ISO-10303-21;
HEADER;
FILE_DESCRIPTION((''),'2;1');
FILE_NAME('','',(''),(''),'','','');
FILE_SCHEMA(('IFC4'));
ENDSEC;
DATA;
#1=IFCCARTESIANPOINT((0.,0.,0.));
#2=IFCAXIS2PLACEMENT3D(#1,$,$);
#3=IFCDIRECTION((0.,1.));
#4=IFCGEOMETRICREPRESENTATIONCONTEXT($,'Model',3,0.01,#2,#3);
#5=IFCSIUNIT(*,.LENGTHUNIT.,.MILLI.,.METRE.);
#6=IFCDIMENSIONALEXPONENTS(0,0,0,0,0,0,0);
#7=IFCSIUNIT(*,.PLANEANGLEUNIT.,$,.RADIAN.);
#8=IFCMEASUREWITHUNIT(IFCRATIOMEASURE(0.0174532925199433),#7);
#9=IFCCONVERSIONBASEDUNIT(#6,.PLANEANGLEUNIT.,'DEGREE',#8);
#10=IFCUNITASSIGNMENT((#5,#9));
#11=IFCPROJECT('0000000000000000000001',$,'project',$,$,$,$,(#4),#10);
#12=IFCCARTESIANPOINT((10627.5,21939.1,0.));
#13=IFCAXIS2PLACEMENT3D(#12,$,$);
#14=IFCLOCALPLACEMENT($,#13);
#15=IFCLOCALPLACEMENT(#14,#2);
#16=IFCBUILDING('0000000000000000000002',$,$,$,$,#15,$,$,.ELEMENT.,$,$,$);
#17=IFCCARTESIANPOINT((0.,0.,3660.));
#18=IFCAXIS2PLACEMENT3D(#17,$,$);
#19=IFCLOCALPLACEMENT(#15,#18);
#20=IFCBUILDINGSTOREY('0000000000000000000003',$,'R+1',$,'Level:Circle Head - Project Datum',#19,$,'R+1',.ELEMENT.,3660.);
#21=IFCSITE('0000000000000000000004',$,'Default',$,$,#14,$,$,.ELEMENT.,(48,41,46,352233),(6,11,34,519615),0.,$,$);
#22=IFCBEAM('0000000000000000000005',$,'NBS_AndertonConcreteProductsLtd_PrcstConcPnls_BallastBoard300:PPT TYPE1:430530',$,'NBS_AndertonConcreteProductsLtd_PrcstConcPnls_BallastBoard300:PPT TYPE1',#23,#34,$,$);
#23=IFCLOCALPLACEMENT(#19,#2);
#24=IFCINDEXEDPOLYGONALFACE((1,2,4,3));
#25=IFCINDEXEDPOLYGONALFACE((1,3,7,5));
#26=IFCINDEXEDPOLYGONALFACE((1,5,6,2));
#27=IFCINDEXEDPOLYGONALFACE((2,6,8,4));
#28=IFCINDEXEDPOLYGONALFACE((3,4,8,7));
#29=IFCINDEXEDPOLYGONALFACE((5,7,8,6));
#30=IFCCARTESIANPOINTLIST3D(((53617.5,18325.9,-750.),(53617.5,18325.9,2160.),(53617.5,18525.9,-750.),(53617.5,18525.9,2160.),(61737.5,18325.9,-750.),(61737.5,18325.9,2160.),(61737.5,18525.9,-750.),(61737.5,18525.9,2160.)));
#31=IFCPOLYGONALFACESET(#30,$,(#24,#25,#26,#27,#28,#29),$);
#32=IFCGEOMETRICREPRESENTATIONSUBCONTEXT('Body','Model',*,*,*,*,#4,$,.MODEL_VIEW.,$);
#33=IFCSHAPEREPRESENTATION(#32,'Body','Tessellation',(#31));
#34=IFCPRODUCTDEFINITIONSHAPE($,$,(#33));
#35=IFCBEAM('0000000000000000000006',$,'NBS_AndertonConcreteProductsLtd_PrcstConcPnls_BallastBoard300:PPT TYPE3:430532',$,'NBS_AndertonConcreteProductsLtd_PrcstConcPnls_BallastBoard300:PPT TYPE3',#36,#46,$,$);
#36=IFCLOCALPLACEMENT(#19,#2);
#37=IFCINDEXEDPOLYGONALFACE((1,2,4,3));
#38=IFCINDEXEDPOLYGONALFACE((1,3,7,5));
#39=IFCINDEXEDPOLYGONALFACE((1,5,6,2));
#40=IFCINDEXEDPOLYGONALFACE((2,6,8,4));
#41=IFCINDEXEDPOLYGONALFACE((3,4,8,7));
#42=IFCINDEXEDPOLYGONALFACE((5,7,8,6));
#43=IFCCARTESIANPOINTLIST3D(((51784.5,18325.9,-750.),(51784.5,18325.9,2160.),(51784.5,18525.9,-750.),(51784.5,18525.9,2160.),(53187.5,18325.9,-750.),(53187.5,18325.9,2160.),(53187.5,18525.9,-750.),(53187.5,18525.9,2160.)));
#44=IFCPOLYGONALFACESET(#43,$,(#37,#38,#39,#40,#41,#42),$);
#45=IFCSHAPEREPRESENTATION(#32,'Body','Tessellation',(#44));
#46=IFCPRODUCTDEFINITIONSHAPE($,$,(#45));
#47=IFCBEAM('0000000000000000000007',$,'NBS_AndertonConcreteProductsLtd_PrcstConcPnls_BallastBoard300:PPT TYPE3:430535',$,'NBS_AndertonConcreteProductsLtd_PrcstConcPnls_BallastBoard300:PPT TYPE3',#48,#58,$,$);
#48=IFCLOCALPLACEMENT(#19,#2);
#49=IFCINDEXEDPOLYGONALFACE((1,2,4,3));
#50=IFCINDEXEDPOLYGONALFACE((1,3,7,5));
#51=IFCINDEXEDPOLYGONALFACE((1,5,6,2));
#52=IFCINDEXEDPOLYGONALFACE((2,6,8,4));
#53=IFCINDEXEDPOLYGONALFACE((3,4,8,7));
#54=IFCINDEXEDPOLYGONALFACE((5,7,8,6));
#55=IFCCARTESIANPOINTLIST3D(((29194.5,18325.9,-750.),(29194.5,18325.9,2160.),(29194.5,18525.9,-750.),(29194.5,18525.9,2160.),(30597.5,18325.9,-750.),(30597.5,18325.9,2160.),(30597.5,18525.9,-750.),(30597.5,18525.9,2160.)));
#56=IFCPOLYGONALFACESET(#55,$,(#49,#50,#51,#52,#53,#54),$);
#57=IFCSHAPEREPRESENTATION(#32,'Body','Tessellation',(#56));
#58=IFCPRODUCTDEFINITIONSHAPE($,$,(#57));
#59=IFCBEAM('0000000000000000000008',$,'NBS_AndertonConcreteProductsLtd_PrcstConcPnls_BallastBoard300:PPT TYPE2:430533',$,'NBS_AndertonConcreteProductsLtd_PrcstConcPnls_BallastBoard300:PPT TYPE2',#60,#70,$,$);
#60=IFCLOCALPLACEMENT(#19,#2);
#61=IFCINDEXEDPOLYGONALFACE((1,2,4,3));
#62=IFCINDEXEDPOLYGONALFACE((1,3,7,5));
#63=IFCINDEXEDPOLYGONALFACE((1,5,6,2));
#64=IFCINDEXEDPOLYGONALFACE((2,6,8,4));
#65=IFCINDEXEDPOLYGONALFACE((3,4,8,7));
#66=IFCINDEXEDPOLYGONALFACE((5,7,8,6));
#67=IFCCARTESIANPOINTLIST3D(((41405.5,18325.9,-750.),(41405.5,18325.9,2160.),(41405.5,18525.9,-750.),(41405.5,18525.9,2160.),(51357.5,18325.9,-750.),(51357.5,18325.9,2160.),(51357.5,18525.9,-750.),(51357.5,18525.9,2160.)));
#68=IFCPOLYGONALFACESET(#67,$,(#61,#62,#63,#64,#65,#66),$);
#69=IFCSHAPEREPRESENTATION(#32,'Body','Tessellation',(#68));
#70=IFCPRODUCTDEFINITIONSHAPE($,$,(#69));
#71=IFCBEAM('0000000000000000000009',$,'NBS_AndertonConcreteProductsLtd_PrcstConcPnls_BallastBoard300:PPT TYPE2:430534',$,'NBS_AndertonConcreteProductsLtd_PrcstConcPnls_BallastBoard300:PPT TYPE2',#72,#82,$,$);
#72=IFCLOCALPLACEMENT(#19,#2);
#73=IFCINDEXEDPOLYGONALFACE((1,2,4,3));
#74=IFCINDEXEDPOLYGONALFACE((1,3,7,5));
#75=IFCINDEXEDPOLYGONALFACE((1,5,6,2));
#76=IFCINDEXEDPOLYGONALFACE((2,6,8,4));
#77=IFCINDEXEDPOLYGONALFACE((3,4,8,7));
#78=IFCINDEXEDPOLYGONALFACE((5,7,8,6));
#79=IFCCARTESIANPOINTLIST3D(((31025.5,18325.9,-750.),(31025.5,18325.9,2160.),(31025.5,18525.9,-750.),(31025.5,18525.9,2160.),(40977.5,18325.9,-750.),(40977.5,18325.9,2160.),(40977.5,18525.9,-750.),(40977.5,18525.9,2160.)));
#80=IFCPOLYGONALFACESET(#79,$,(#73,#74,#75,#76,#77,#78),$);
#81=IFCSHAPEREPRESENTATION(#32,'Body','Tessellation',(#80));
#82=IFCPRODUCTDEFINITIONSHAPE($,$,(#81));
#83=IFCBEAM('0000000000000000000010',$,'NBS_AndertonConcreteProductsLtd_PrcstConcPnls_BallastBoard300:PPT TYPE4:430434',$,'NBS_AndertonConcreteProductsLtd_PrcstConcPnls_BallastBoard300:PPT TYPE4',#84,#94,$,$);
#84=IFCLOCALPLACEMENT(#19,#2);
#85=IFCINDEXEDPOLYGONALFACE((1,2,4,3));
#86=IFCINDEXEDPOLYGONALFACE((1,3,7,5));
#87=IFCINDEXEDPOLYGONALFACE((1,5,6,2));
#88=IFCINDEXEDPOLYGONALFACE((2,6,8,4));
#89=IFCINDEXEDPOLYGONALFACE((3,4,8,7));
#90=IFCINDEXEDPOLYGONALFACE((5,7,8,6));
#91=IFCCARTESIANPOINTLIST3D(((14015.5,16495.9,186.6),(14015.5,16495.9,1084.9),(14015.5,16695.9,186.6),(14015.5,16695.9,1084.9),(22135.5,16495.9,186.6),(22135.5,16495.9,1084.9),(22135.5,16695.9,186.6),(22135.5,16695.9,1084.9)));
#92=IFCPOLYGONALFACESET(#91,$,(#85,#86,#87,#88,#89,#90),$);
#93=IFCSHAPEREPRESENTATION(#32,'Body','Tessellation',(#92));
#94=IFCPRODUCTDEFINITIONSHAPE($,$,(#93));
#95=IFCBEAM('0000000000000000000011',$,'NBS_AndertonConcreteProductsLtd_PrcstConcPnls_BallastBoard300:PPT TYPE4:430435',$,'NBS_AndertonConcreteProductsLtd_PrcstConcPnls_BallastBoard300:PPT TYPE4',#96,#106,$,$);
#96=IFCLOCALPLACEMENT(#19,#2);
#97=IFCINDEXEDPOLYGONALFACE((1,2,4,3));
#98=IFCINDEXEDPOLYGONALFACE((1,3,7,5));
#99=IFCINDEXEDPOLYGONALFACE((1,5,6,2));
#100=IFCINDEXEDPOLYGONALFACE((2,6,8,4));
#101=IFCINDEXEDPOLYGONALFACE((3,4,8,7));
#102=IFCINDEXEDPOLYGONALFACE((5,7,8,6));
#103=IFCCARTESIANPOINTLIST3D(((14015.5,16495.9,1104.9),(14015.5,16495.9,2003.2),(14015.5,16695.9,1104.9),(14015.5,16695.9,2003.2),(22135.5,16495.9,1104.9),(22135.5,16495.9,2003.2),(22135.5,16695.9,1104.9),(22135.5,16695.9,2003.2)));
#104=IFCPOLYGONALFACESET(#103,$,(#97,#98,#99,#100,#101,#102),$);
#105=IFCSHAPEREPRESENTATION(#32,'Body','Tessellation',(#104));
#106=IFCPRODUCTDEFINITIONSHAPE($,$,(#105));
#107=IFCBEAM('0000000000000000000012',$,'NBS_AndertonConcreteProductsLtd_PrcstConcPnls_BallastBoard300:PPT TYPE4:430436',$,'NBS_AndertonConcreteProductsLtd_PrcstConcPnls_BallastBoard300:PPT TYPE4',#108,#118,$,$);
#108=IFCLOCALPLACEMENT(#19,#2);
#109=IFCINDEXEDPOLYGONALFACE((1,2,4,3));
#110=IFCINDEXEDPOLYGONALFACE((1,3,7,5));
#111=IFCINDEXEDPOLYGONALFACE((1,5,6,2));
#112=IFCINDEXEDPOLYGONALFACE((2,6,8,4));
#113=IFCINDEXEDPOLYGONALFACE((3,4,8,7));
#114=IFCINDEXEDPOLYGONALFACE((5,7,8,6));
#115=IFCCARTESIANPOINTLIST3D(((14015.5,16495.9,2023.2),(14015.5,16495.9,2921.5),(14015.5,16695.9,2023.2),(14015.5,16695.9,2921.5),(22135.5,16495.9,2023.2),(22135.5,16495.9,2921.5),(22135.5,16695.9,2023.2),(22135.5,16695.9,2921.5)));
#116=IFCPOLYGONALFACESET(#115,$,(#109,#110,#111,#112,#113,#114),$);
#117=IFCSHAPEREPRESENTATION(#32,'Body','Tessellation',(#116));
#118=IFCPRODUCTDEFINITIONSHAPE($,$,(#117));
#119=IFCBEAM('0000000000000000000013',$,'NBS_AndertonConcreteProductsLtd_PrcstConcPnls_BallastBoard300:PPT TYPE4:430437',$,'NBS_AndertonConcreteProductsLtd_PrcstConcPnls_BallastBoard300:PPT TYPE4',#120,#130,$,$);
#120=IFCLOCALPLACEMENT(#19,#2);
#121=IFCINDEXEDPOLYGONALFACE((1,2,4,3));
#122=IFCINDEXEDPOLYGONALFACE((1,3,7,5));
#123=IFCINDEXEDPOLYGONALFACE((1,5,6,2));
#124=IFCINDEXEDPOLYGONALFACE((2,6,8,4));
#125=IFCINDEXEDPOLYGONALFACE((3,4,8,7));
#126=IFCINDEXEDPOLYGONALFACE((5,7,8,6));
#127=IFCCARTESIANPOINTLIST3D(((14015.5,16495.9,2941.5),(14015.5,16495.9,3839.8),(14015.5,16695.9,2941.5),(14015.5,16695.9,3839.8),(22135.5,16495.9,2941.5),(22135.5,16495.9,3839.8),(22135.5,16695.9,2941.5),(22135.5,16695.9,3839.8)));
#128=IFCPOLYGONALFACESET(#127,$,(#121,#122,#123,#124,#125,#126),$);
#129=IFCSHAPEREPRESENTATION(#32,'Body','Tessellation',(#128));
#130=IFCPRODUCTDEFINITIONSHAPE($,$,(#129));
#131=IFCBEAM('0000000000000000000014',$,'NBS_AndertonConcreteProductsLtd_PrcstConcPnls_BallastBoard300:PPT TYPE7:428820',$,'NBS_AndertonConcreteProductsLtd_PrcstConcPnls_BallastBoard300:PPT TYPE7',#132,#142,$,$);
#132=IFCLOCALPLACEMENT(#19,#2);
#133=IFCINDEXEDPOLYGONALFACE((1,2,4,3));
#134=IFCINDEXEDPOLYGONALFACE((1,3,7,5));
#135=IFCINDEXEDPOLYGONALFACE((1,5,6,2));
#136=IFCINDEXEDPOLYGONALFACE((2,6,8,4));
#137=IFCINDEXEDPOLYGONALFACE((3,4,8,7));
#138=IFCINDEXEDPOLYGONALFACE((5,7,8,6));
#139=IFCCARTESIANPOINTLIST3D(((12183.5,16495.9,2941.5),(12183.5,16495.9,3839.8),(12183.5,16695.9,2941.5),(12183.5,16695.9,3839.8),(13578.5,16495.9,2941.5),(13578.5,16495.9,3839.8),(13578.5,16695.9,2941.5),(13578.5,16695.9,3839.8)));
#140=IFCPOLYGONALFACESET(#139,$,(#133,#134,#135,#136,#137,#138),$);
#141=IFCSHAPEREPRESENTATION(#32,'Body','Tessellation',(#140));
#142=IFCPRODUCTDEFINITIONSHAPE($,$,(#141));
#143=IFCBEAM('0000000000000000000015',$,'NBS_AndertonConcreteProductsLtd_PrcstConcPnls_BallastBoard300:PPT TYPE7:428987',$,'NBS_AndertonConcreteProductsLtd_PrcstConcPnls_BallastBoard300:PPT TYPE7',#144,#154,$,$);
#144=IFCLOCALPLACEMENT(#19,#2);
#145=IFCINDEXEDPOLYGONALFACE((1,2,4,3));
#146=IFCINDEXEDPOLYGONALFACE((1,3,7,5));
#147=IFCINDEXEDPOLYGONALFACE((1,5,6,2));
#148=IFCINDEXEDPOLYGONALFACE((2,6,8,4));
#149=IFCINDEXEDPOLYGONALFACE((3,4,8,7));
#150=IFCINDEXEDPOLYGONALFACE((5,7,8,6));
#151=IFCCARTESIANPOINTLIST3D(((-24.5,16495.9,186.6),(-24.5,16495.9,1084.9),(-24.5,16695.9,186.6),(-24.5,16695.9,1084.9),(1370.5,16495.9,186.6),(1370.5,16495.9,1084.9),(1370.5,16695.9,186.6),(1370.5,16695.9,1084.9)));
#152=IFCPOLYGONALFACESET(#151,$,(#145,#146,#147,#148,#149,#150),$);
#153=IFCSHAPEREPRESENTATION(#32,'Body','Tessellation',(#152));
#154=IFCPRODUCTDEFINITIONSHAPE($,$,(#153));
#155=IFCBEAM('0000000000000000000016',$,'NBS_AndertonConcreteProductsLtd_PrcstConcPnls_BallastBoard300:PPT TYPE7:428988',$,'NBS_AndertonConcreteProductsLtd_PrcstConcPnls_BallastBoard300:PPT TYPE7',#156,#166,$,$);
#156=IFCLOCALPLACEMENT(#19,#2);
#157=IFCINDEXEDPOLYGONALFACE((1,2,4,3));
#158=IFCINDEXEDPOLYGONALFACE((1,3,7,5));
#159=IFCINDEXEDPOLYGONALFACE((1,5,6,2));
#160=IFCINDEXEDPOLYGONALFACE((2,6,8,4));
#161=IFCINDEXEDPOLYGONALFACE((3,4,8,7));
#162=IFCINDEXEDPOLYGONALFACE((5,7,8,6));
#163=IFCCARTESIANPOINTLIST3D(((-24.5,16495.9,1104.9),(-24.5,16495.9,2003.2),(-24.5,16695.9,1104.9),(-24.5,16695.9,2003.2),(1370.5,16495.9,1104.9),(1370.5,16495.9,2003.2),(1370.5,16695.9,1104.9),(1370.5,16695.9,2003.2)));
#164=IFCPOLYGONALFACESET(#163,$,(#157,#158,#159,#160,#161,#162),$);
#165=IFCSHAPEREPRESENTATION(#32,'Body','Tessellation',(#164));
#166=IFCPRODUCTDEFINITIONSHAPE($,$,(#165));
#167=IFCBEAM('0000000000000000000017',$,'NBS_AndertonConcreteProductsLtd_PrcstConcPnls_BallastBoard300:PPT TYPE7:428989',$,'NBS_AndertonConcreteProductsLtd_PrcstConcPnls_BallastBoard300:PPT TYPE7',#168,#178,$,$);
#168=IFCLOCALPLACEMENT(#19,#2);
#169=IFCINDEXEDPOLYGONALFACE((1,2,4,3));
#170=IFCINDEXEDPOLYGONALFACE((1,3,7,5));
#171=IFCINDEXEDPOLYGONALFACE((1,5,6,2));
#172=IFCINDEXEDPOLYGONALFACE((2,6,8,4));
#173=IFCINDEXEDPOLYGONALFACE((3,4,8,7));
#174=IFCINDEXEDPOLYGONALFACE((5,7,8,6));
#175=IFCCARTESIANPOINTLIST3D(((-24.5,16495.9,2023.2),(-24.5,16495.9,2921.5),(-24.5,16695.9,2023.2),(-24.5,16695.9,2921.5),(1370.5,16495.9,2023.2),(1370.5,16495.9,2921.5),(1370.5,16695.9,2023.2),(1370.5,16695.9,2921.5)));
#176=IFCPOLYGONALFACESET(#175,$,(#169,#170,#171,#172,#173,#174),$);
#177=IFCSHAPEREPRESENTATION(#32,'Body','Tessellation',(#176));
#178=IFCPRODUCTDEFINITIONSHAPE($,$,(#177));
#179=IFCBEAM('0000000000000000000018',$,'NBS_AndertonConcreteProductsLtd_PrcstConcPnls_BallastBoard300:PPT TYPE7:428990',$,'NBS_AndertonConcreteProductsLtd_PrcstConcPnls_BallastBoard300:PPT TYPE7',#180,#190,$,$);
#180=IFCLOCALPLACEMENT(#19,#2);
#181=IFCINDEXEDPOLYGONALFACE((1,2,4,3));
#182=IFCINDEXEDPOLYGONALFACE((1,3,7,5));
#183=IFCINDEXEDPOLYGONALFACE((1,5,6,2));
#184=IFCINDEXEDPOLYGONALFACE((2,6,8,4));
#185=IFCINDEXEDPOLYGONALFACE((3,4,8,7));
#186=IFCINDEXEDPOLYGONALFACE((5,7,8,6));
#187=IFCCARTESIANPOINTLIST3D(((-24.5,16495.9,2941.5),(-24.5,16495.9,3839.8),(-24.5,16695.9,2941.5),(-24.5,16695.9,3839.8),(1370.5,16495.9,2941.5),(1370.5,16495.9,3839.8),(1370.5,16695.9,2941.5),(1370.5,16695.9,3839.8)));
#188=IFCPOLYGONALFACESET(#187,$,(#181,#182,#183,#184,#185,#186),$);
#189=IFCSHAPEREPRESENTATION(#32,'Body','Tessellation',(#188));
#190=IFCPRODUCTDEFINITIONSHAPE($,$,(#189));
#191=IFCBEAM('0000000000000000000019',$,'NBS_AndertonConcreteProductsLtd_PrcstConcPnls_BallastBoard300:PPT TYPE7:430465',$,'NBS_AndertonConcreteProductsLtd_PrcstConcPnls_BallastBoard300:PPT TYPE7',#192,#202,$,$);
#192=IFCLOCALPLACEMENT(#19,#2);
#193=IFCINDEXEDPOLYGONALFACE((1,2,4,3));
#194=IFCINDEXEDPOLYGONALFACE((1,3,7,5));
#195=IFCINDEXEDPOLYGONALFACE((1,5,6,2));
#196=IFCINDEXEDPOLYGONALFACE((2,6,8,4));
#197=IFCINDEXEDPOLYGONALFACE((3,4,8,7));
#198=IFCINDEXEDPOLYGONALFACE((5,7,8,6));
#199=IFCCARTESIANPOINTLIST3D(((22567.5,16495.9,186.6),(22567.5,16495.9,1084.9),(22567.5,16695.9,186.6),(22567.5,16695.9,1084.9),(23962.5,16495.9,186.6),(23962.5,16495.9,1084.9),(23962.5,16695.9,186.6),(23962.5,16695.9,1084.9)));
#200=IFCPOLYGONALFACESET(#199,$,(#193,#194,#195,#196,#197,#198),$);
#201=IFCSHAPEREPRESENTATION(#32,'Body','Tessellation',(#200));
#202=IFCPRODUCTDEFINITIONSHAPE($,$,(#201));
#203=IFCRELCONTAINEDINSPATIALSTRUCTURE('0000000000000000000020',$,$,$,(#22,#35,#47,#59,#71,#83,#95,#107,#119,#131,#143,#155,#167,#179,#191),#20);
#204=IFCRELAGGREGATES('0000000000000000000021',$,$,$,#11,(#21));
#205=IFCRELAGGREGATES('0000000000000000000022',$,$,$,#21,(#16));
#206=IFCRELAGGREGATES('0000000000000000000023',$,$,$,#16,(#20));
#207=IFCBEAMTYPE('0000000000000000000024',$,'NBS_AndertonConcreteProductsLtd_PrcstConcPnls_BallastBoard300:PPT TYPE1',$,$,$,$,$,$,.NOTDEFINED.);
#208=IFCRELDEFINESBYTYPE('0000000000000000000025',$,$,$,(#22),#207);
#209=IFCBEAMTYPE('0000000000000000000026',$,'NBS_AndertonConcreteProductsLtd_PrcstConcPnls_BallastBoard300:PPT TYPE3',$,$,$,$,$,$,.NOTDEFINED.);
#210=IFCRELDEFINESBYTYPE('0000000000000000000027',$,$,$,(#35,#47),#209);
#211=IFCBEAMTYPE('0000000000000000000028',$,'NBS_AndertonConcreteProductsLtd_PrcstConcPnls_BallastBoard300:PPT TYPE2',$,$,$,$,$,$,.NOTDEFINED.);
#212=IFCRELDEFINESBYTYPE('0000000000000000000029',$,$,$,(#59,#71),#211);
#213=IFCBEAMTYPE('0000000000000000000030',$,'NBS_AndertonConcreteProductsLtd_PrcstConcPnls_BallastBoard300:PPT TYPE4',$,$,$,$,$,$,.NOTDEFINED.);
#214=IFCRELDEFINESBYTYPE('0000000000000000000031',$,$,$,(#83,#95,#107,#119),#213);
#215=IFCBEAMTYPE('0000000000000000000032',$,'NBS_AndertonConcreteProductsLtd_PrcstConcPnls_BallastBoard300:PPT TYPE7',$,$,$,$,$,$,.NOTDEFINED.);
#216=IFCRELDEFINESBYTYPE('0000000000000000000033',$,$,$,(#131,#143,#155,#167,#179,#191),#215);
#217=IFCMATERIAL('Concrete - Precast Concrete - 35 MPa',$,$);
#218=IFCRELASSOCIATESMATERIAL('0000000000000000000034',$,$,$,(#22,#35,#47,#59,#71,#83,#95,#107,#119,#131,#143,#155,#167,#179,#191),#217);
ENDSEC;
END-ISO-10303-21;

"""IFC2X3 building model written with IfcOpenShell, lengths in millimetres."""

from ifc_helpers import new_model, entity, si_unit, converted_unit, direction, frame, frame_2d, origin, place, context, subcontext, project, spatial, rectangle, extrude, material, type_object, element, save


model = new_model("IFC2X3")

# Units and contexts
model_context = context("Model", 3, precision=0.01, world=origin(), true_north=direction((0.0, 1.0)))
body_context = subcontext(model_context, "Body", "Model", "MODEL_VIEW")
ifc_project = project(units=[si_unit("LENGTHUNIT", "METRE", prefix="MILLI"), converted_unit("PLANEANGLEUNIT", "DEGREE", entity("IfcRatioMeasure", 0.0174532925199433), si_unit("PLANEANGLEUNIT", "RADIAN"), dimensions=[0, 0, 0, 0, 0, 0, 0])], contexts=[model_context])

# Site, building, storey
site_placement = place(None, frame((10627.5, 21939.1, 0.0)))
site = spatial("IfcSite", under=ifc_project, at=site_placement, Name="Default", CompositionType="ELEMENT", RefLatitude=(48, 41, 46, 352233), RefLongitude=(6, 11, 34, 519615), RefElevation=0.0)
building_placement = place(site_placement, origin())
building = spatial("IfcBuilding", under=site, at=building_placement, CompositionType="ELEMENT")
storey_placement = place(building_placement, frame((0.0, 0.0, 3660.0)))
storey = spatial("IfcBuildingStorey", under=building, at=storey_placement, Name="R+1", ObjectType="Level:Circle Head - Project Datum", LongName="R+1", CompositionType="ELEMENT", Elevation=3660.0)

# Beams
ifc_material_1 = material(Name="Concrete - Precast Concrete - 35 MPa")
beam_type_1 = type_object("IfcBeamType", Name="NBS_AndertonConcreteProductsLtd_PrcstConcPnls_BallastBoard300:PPT TYPE1", PredefinedType="NOTDEFINED")
beam_1_placement = place(storey_placement, origin())
element("IfcBeam", 1, at=beam_1_placement, inside=storey, type_object=beam_type_1, material=ifc_material_1, Name="NBS_AndertonConcreteProductsLtd_PrcstConcPnls_BallastBoard300:PPT TYPE1:430530", ObjectType="NBS_AndertonConcreteProductsLtd_PrcstConcPnls_BallastBoard300:PPT TYPE1", context=body_context, shape_type="SweptSolid", body=[
    extrude(rectangle(XDim=2910.0, YDim=200.0, at=frame_2d((0.0, 0.0), x_axis=(1.0, 0.0))), frame((53617.5, 18425.9, 705.0), z_axis=(1.0, 0.0, 0.0), x_axis=(0.0, 0.0, -1.0)), (0.0, 0.0, 1.0), 8120.0),
])
beam_type_2 = type_object("IfcBeamType", Name="NBS_AndertonConcreteProductsLtd_PrcstConcPnls_BallastBoard300:PPT TYPE3", PredefinedType="NOTDEFINED")
beam_2_placement = place(storey_placement, origin())
element("IfcBeam", 2, at=beam_2_placement, inside=storey, type_object=beam_type_2, material=ifc_material_1, Name="NBS_AndertonConcreteProductsLtd_PrcstConcPnls_BallastBoard300:PPT TYPE3:430532", ObjectType="NBS_AndertonConcreteProductsLtd_PrcstConcPnls_BallastBoard300:PPT TYPE3", context=body_context, shape_type="SweptSolid", body=[
    extrude(rectangle(XDim=2910.0, YDim=200.0, at=frame_2d((0.0, 0.0), x_axis=(1.0, 0.0))), frame((51784.5, 18425.9, 705.0), z_axis=(1.0, 0.0, 0.0), x_axis=(0.0, 0.0, -1.0)), (0.0, 0.0, 1.0), 1403.0),
])
beam_3_placement = place(storey_placement, origin())
element("IfcBeam", 3, at=beam_3_placement, inside=storey, type_object=beam_type_2, material=ifc_material_1, Name="NBS_AndertonConcreteProductsLtd_PrcstConcPnls_BallastBoard300:PPT TYPE3:430535", ObjectType="NBS_AndertonConcreteProductsLtd_PrcstConcPnls_BallastBoard300:PPT TYPE3", context=body_context, shape_type="SweptSolid", body=[
    extrude(rectangle(XDim=2910.0, YDim=200.0, at=frame_2d((0.0, 0.0), x_axis=(1.0, 0.0))), frame((29194.5, 18425.9, 705.0), z_axis=(1.0, 0.0, 0.0), x_axis=(0.0, 0.0, -1.0)), (0.0, 0.0, 1.0), 1403.0),
])
beam_type_3 = type_object("IfcBeamType", Name="NBS_AndertonConcreteProductsLtd_PrcstConcPnls_BallastBoard300:PPT TYPE2", PredefinedType="NOTDEFINED")
beam_4_placement = place(storey_placement, origin())
element("IfcBeam", 4, at=beam_4_placement, inside=storey, type_object=beam_type_3, material=ifc_material_1, Name="NBS_AndertonConcreteProductsLtd_PrcstConcPnls_BallastBoard300:PPT TYPE2:430533", ObjectType="NBS_AndertonConcreteProductsLtd_PrcstConcPnls_BallastBoard300:PPT TYPE2", context=body_context, shape_type="SweptSolid", body=[
    extrude(rectangle(XDim=2910.0, YDim=200.0, at=frame_2d((0.0, 0.0), x_axis=(1.0, 0.0))), frame((41405.5, 18425.9, 705.0), z_axis=(1.0, 0.0, 0.0), x_axis=(0.0, 0.0, -1.0)), (0.0, 0.0, 1.0), 9952.0),
])
beam_5_placement = place(storey_placement, origin())
element("IfcBeam", 5, at=beam_5_placement, inside=storey, type_object=beam_type_3, material=ifc_material_1, Name="NBS_AndertonConcreteProductsLtd_PrcstConcPnls_BallastBoard300:PPT TYPE2:430534", ObjectType="NBS_AndertonConcreteProductsLtd_PrcstConcPnls_BallastBoard300:PPT TYPE2", context=body_context, shape_type="SweptSolid", body=[
    extrude(rectangle(XDim=2910.0, YDim=200.0, at=frame_2d((0.0, 0.0), x_axis=(1.0, 0.0))), frame((31025.5, 18425.9, 705.0), z_axis=(1.0, 0.0, 0.0), x_axis=(0.0, 0.0, -1.0)), (0.0, 0.0, 1.0), 9952.0),
])
beam_type_4 = type_object("IfcBeamType", Name="NBS_AndertonConcreteProductsLtd_PrcstConcPnls_BallastBoard300:PPT TYPE4", PredefinedType="NOTDEFINED")
beam_6_placement = place(storey_placement, origin())
element("IfcBeam", 6, at=beam_6_placement, inside=storey, type_object=beam_type_4, material=ifc_material_1, Name="NBS_AndertonConcreteProductsLtd_PrcstConcPnls_BallastBoard300:PPT TYPE4:430434", ObjectType="NBS_AndertonConcreteProductsLtd_PrcstConcPnls_BallastBoard300:PPT TYPE4", context=body_context, shape_type="SweptSolid", body=[
    extrude(rectangle(XDim=898.3, YDim=200.0, at=frame_2d((0.0, 0.0), x_axis=(0.0, 1.0))), frame((14015.5, 16595.9, 635.8), z_axis=(1.0, 0.0, 0.0), x_axis=(0.0, 1.0, 0.0)), (0.0, 0.0, 1.0), 8120.0),
])
beam_7_placement = place(storey_placement, origin())
element("IfcBeam", 7, at=beam_7_placement, inside=storey, type_object=beam_type_4, material=ifc_material_1, Name="NBS_AndertonConcreteProductsLtd_PrcstConcPnls_BallastBoard300:PPT TYPE4:430435", ObjectType="NBS_AndertonConcreteProductsLtd_PrcstConcPnls_BallastBoard300:PPT TYPE4", context=body_context, shape_type="SweptSolid", body=[
    extrude(rectangle(XDim=898.3, YDim=200.0, at=frame_2d((0.0, 0.0), x_axis=(0.0, 1.0))), frame((14015.5, 16595.9, 1554.1), z_axis=(1.0, 0.0, 0.0), x_axis=(0.0, 1.0, 0.0)), (0.0, 0.0, 1.0), 8120.0),
])
beam_8_placement = place(storey_placement, origin())
element("IfcBeam", 8, at=beam_8_placement, inside=storey, type_object=beam_type_4, material=ifc_material_1, Name="NBS_AndertonConcreteProductsLtd_PrcstConcPnls_BallastBoard300:PPT TYPE4:430436", ObjectType="NBS_AndertonConcreteProductsLtd_PrcstConcPnls_BallastBoard300:PPT TYPE4", context=body_context, shape_type="SweptSolid", body=[
    extrude(rectangle(XDim=898.3, YDim=200.0, at=frame_2d((0.0, 0.0), x_axis=(0.0, 1.0))), frame((14015.5, 16595.9, 2472.4), z_axis=(1.0, 0.0, 0.0), x_axis=(0.0, 1.0, 0.0)), (0.0, 0.0, 1.0), 8120.0),
])
beam_9_placement = place(storey_placement, origin())
element("IfcBeam", 9, at=beam_9_placement, inside=storey, type_object=beam_type_4, material=ifc_material_1, Name="NBS_AndertonConcreteProductsLtd_PrcstConcPnls_BallastBoard300:PPT TYPE4:430437", ObjectType="NBS_AndertonConcreteProductsLtd_PrcstConcPnls_BallastBoard300:PPT TYPE4", context=body_context, shape_type="SweptSolid", body=[
    extrude(rectangle(XDim=898.3, YDim=200.0, at=frame_2d((0.0, 0.0), x_axis=(0.0, 1.0))), frame((14015.5, 16595.9, 3390.7), z_axis=(1.0, 0.0, 0.0), x_axis=(0.0, 1.0, 0.0)), (0.0, 0.0, 1.0), 8120.0),
])
beam_type_5 = type_object("IfcBeamType", Name="NBS_AndertonConcreteProductsLtd_PrcstConcPnls_BallastBoard300:PPT TYPE7", PredefinedType="NOTDEFINED")
beam_10_placement = place(storey_placement, origin())
element("IfcBeam", 10, at=beam_10_placement, inside=storey, type_object=beam_type_5, material=ifc_material_1, Name="NBS_AndertonConcreteProductsLtd_PrcstConcPnls_BallastBoard300:PPT TYPE7:428820", ObjectType="NBS_AndertonConcreteProductsLtd_PrcstConcPnls_BallastBoard300:PPT TYPE7", context=body_context, shape_type="SweptSolid", body=[
    extrude(rectangle(XDim=898.3, YDim=200.0, at=frame_2d((0.0, 0.0), x_axis=(0.0, 1.0))), frame((12183.5, 16595.9, 3390.7), z_axis=(1.0, 0.0, 0.0), x_axis=(0.0, 1.0, 0.0)), (0.0, 0.0, 1.0), 1395.0),
])
beam_11_placement = place(storey_placement, origin())
element("IfcBeam", 11, at=beam_11_placement, inside=storey, type_object=beam_type_5, material=ifc_material_1, Name="NBS_AndertonConcreteProductsLtd_PrcstConcPnls_BallastBoard300:PPT TYPE7:428987", ObjectType="NBS_AndertonConcreteProductsLtd_PrcstConcPnls_BallastBoard300:PPT TYPE7", context=body_context, shape_type="SweptSolid", body=[
    extrude(rectangle(XDim=898.3, YDim=200.0, at=frame_2d((0.0, 0.0), x_axis=(0.0, 1.0))), frame((-24.5, 16595.9, 635.8), z_axis=(1.0, 0.0, 0.0), x_axis=(0.0, 1.0, 0.0)), (0.0, 0.0, 1.0), 1395.0),
])
beam_12_placement = place(storey_placement, origin())
element("IfcBeam", 12, at=beam_12_placement, inside=storey, type_object=beam_type_5, material=ifc_material_1, Name="NBS_AndertonConcreteProductsLtd_PrcstConcPnls_BallastBoard300:PPT TYPE7:428988", ObjectType="NBS_AndertonConcreteProductsLtd_PrcstConcPnls_BallastBoard300:PPT TYPE7", context=body_context, shape_type="SweptSolid", body=[
    extrude(rectangle(XDim=898.3, YDim=200.0, at=frame_2d((0.0, 0.0), x_axis=(0.0, 1.0))), frame((-24.5, 16595.9, 1554.1), z_axis=(1.0, 0.0, 0.0), x_axis=(0.0, 1.0, 0.0)), (0.0, 0.0, 1.0), 1395.0),
])
beam_13_placement = place(storey_placement, origin())
element("IfcBeam", 13, at=beam_13_placement, inside=storey, type_object=beam_type_5, material=ifc_material_1, Name="NBS_AndertonConcreteProductsLtd_PrcstConcPnls_BallastBoard300:PPT TYPE7:428989", ObjectType="NBS_AndertonConcreteProductsLtd_PrcstConcPnls_BallastBoard300:PPT TYPE7", context=body_context, shape_type="SweptSolid", body=[
    extrude(rectangle(XDim=898.3, YDim=200.0, at=frame_2d((0.0, 0.0), x_axis=(0.0, 1.0))), frame((-24.5, 16595.9, 2472.4), z_axis=(1.0, 0.0, 0.0), x_axis=(0.0, 1.0, 0.0)), (0.0, 0.0, 1.0), 1395.0),
])
beam_14_placement = place(storey_placement, origin())
element("IfcBeam", 14, at=beam_14_placement, inside=storey, type_object=beam_type_5, material=ifc_material_1, Name="NBS_AndertonConcreteProductsLtd_PrcstConcPnls_BallastBoard300:PPT TYPE7:428990", ObjectType="NBS_AndertonConcreteProductsLtd_PrcstConcPnls_BallastBoard300:PPT TYPE7", context=body_context, shape_type="SweptSolid", body=[
    extrude(rectangle(XDim=898.3, YDim=200.0, at=frame_2d((0.0, 0.0), x_axis=(0.0, 1.0))), frame((-24.5, 16595.9, 3390.7), z_axis=(1.0, 0.0, 0.0), x_axis=(0.0, 1.0, 0.0)), (0.0, 0.0, 1.0), 1395.0),
])
beam_15_placement = place(storey_placement, origin())
element("IfcBeam", 15, at=beam_15_placement, inside=storey, type_object=beam_type_5, material=ifc_material_1, Name="NBS_AndertonConcreteProductsLtd_PrcstConcPnls_BallastBoard300:PPT TYPE7:430465", ObjectType="NBS_AndertonConcreteProductsLtd_PrcstConcPnls_BallastBoard300:PPT TYPE7", context=body_context, shape_type="SweptSolid", body=[
    extrude(rectangle(XDim=898.3, YDim=200.0, at=frame_2d((0.0, 0.0), x_axis=(0.0, 1.0))), frame((22567.5, 16595.9, 635.8), z_axis=(1.0, 0.0, 0.0), x_axis=(0.0, 1.0, 0.0)), (0.0, 0.0, 1.0), 1395.0),
])

save(model, "model.ifc")
